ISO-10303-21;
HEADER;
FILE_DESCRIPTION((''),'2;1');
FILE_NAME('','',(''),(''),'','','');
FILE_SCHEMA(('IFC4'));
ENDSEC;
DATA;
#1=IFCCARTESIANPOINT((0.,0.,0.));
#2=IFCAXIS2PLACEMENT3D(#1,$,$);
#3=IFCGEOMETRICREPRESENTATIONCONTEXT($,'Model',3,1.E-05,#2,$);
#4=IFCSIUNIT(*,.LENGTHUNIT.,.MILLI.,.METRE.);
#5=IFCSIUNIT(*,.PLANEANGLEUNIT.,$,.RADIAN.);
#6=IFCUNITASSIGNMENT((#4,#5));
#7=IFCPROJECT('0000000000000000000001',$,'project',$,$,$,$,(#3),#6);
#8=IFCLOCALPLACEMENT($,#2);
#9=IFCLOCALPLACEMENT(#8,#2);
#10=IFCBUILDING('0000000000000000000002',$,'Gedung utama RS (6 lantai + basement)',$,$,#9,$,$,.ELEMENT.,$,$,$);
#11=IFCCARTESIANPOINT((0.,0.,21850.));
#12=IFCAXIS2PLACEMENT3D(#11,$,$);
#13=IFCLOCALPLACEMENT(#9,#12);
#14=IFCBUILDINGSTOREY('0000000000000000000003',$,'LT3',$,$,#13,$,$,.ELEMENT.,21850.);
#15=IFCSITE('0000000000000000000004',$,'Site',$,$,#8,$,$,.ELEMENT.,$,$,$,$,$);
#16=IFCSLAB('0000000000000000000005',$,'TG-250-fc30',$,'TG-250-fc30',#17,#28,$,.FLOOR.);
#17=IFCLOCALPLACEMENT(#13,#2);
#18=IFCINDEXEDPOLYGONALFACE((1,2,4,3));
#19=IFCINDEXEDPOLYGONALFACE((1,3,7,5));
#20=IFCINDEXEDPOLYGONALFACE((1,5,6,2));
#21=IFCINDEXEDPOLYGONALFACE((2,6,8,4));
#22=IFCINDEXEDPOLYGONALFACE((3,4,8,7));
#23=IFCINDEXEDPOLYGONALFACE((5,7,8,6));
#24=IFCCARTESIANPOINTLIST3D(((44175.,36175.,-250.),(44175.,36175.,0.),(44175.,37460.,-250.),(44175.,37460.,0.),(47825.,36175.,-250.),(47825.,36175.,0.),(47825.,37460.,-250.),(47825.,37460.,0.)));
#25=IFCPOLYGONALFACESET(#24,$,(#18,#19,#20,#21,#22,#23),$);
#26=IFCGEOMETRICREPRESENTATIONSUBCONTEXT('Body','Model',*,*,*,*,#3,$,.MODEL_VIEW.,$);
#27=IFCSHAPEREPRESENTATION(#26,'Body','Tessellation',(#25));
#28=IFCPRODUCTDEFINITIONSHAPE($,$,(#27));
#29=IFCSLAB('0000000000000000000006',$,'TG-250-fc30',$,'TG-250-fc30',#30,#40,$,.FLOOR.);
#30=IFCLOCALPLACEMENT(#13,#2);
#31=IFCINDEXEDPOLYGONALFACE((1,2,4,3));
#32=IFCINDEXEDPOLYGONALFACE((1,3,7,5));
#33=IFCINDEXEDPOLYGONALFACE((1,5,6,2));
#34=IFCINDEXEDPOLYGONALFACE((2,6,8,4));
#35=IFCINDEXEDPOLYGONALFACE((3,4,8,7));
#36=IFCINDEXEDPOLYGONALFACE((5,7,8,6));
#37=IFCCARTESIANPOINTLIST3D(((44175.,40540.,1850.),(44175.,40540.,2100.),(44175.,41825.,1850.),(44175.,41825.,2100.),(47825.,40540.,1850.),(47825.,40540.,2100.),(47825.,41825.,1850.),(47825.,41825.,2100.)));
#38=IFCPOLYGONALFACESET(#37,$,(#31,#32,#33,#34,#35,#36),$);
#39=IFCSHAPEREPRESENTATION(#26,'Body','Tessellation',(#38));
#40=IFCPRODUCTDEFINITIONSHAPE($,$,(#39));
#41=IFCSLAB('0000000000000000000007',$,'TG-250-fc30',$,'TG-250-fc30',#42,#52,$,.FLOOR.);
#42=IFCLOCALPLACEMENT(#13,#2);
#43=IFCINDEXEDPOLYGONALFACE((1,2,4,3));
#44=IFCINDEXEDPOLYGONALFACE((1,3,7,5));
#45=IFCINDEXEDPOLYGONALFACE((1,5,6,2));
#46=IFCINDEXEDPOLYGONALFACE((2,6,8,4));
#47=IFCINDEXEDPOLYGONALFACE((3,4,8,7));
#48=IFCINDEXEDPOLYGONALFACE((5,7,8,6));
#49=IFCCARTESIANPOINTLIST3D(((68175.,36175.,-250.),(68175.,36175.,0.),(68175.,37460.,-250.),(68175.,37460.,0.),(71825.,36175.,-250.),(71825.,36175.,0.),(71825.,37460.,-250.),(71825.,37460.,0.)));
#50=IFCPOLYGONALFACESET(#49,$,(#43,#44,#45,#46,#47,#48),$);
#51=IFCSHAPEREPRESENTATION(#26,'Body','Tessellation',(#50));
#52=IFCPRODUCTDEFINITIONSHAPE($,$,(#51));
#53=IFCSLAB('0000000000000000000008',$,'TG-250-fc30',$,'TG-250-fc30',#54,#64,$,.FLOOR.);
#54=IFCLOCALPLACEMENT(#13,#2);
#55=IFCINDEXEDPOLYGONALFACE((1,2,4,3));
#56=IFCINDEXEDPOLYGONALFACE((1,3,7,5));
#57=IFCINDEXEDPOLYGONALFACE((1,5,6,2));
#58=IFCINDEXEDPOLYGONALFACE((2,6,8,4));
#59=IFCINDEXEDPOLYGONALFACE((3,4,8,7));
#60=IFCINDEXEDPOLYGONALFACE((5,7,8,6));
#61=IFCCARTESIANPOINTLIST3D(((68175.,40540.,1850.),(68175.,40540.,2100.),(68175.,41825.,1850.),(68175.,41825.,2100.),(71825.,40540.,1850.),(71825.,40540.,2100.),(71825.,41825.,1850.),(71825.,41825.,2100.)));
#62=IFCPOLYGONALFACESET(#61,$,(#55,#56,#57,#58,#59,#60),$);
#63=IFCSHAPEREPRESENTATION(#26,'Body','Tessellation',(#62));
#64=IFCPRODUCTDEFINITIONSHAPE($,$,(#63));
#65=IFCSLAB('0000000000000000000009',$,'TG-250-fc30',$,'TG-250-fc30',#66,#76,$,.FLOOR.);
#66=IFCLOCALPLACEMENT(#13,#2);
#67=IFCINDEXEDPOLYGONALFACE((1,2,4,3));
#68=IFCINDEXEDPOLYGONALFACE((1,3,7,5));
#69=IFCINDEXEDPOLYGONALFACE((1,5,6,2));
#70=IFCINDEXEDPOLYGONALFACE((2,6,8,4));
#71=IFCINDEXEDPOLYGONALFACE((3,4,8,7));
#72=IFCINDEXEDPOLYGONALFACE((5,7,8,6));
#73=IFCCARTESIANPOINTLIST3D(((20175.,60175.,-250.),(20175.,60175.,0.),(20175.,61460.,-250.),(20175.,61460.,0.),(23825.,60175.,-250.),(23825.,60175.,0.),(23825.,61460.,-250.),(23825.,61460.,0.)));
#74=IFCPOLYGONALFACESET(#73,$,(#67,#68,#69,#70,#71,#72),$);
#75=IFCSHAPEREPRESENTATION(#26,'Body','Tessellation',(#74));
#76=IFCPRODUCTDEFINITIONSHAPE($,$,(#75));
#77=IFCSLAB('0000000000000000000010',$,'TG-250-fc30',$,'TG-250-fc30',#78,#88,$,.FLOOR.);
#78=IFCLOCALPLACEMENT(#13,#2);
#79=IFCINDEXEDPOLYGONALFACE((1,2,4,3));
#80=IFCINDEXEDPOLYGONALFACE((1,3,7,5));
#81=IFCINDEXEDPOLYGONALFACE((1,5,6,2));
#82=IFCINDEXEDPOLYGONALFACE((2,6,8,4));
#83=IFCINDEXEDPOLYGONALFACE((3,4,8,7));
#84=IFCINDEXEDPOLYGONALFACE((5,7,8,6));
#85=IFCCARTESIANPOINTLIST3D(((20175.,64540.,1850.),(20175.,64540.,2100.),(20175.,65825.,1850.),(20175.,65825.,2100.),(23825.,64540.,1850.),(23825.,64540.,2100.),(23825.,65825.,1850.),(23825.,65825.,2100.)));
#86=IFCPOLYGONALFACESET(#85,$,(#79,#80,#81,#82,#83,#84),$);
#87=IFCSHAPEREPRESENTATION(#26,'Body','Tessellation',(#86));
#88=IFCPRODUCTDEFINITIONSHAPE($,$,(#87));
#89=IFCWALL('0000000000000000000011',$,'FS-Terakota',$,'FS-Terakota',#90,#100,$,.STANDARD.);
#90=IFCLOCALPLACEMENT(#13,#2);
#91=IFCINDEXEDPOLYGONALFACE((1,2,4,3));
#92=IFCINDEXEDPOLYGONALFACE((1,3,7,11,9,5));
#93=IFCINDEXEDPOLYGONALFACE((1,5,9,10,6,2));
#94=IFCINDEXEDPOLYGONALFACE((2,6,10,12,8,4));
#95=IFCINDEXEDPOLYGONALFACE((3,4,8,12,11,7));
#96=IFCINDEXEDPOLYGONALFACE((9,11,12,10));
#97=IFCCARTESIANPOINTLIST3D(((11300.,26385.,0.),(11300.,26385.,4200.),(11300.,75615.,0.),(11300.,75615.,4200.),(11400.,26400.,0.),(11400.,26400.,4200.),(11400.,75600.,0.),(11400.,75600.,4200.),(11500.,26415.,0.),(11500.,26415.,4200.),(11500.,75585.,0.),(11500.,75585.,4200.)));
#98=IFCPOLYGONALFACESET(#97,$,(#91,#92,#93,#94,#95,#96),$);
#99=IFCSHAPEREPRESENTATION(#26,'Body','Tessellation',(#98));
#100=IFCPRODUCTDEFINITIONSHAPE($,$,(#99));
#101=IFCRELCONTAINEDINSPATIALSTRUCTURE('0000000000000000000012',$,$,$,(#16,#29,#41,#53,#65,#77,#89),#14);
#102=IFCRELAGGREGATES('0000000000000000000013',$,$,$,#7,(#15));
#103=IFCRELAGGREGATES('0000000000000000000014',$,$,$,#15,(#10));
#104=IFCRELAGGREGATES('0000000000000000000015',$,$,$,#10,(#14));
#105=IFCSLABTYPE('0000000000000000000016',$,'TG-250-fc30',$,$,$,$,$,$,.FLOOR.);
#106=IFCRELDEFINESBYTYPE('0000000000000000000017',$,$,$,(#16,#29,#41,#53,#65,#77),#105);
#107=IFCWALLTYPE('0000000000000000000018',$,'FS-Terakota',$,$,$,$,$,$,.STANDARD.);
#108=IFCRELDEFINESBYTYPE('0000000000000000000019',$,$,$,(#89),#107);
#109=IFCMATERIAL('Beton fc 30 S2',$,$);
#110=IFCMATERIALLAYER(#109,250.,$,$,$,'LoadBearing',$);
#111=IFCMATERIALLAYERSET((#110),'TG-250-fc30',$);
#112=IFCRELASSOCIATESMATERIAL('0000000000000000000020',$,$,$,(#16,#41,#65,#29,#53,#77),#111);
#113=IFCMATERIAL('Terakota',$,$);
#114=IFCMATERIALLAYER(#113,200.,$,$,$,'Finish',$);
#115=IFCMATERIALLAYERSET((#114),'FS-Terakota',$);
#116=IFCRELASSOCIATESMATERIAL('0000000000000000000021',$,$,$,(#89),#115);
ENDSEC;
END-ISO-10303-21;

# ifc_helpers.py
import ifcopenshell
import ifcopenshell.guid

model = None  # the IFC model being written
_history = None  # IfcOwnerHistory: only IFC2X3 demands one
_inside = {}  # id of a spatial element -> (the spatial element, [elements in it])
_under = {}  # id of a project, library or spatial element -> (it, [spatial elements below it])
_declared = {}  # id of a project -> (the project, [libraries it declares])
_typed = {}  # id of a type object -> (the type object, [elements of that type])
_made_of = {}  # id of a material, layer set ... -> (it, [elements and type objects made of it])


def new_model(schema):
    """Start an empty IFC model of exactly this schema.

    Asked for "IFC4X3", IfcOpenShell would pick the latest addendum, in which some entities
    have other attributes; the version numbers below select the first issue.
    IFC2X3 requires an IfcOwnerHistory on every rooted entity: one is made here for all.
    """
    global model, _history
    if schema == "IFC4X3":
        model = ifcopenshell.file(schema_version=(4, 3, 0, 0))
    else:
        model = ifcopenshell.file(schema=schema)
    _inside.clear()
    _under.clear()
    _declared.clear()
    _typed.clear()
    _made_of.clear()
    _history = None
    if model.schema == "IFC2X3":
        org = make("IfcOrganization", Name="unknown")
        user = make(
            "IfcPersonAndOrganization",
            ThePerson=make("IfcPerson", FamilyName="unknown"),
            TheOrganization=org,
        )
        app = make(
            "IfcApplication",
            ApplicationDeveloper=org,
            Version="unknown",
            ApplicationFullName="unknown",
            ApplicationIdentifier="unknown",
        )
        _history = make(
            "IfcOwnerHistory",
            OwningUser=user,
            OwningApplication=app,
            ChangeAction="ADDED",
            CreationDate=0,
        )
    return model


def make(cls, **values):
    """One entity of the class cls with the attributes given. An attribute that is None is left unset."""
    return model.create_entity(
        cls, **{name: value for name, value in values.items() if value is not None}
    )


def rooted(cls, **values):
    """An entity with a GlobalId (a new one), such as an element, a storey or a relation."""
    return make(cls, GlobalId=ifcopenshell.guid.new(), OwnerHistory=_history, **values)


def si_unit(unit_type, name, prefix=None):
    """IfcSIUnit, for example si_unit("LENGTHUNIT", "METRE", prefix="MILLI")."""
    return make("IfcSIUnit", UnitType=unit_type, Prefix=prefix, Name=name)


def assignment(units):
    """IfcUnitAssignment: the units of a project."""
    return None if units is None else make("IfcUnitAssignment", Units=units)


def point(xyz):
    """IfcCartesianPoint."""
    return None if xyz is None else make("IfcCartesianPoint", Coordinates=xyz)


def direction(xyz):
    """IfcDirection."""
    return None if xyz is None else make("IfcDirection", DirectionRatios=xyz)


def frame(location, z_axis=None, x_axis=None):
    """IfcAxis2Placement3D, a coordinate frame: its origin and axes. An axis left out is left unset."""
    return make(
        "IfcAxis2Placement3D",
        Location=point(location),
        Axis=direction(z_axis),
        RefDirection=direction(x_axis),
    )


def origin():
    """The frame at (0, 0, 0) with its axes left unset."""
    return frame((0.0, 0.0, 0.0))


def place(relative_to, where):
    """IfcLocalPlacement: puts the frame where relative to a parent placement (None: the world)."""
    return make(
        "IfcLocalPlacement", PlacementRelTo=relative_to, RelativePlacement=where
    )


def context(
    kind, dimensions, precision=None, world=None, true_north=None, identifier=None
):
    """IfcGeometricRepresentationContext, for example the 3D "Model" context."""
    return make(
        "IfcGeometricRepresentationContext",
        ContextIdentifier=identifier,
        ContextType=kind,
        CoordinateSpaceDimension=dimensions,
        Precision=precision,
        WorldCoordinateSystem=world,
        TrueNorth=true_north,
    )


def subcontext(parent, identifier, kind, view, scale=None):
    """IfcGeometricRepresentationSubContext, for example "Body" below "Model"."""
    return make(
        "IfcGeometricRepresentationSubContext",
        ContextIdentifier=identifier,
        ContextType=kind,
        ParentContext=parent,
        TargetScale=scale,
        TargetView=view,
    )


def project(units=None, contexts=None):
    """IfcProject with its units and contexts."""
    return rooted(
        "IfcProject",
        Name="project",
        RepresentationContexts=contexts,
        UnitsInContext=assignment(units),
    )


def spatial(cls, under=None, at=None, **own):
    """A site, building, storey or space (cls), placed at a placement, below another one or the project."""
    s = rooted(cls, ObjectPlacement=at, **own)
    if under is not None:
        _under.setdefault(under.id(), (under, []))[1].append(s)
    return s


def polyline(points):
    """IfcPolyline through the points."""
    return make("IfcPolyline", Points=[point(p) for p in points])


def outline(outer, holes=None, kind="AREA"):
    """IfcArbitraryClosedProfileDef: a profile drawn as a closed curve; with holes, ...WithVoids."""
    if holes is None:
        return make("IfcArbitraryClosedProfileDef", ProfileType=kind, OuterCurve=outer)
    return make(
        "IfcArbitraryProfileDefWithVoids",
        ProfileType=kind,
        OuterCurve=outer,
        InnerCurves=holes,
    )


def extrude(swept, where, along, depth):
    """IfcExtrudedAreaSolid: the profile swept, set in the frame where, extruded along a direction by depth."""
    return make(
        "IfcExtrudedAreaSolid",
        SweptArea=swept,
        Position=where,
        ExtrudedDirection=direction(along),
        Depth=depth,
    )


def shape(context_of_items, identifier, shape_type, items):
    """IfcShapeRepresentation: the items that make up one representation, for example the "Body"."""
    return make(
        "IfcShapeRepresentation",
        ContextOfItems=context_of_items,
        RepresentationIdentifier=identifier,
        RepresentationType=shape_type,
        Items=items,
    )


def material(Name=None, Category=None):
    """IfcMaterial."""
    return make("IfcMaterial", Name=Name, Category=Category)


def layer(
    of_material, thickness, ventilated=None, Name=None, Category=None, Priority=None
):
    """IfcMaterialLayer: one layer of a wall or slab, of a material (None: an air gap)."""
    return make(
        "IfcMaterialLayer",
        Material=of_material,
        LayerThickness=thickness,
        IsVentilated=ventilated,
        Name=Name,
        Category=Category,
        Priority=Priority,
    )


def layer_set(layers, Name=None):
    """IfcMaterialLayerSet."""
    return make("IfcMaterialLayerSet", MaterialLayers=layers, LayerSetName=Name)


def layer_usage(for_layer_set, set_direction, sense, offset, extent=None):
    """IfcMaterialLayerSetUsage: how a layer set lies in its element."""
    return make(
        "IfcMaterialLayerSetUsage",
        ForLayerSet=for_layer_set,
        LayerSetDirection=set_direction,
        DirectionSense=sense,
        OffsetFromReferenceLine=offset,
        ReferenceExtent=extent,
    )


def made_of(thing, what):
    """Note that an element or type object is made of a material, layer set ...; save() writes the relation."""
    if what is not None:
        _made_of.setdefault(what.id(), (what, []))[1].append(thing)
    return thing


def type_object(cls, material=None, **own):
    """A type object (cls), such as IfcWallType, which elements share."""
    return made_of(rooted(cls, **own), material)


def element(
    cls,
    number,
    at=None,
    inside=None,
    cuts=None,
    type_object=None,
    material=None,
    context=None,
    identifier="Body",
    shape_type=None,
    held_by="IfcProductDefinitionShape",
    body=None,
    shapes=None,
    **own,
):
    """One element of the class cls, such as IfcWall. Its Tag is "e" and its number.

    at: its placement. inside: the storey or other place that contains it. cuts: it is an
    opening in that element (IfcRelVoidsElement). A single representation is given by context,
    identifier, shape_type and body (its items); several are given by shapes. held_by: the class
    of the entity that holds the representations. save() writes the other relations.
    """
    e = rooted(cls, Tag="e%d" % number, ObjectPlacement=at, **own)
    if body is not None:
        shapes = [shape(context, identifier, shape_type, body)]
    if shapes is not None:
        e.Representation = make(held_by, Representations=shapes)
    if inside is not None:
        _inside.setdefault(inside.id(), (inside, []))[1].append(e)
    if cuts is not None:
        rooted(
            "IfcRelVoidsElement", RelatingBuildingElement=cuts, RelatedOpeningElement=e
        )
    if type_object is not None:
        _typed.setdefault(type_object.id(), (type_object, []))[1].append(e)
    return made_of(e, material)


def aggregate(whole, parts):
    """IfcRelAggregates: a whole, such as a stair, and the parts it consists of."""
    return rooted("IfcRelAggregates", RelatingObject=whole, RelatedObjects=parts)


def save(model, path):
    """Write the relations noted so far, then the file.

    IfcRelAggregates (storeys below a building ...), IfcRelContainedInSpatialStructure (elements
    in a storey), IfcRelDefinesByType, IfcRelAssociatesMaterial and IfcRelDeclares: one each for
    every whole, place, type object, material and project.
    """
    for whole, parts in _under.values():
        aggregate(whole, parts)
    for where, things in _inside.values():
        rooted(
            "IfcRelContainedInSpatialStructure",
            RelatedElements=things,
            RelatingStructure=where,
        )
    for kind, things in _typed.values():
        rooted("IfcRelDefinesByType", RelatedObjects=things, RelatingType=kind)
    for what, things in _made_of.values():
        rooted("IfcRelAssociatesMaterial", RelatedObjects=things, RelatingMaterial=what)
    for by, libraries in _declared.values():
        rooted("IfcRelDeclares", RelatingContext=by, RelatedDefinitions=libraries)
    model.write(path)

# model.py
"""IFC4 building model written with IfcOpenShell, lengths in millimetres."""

from ifc_helpers import new_model, si_unit, frame, origin, place, context, subcontext, project, spatial, polyline, outline, extrude, material, layer, layer_set, layer_usage, type_object, element, save


model = new_model("IFC4")

# Units and contexts
model_context = context("Model", 3, precision=1e-05, world=origin())
body_context = subcontext(model_context, "Body", "Model", "MODEL_VIEW")
ifc_project = project(units=[si_unit("LENGTHUNIT", "METRE", prefix="MILLI"), si_unit("PLANEANGLEUNIT", "RADIAN")], contexts=[model_context])

# Site, building, storey
site_placement = place(None, origin())
site = spatial("IfcSite", under=ifc_project, at=site_placement, Name="Site", CompositionType="ELEMENT")
building_placement = place(site_placement, origin())
building = spatial("IfcBuilding", under=site, at=building_placement, Name="Gedung utama RS (6 lantai + basement)", CompositionType="ELEMENT")
storey_placement = place(building_placement, frame((0.0, 0.0, 21850.0)))
storey = spatial("IfcBuildingStorey", under=building, at=storey_placement, Name="LT3", CompositionType="ELEMENT", Elevation=21850.0)

# Shared definitions
ifc_material_1 = material(Name="Beton fc 30 S2")

# Slabs
ifc_layer_1 = layer(ifc_material_1, 250.0, Category="LoadBearing")
ifc_layer_set_1 = layer_set([ifc_layer_1], Name="TG-250-fc30")
ifc_layer_usage_1 = layer_usage(ifc_layer_set_1, "AXIS3", "NEGATIVE", 0.0)
slab_type_1 = type_object("IfcSlabType", Name="TG-250-fc30", PredefinedType="FLOOR")
ifc_layer_usage_2 = layer_usage(ifc_layer_set_1, "AXIS3", "NEGATIVE", 2100.0)
slab_1_placement = place(storey_placement, origin())
element("IfcSlab", 1, at=slab_1_placement, inside=storey, type_object=slab_type_1, material=ifc_layer_usage_1, Name="TG-250-fc30", ObjectType="TG-250-fc30", PredefinedType="FLOOR", context=body_context, shape_type="SweptSolid", body=[
    extrude(outline(polyline([(47825.0, 36175.0), (47825.0, 37460.0), (44175.0, 37460.0), (44175.0, 36175.0), (47825.0, 36175.0)])), frame((0.0, 0.0, -250.0)), (0.0, 0.0, 1.0), 250.0),
])
slab_2_placement = place(storey_placement, origin())
element("IfcSlab", 2, at=slab_2_placement, inside=storey, type_object=slab_type_1, material=ifc_layer_usage_2, Name="TG-250-fc30", ObjectType="TG-250-fc30", PredefinedType="FLOOR", context=body_context, shape_type="SweptSolid", body=[
    extrude(outline(polyline([(47825.0, 40540.0), (47825.0, 41825.0), (44175.0, 41825.0), (44175.0, 40540.0), (47825.0, 40540.0)])), frame((0.0, 0.0, 1850.0)), (0.0, 0.0, 1.0), 250.0),
])
slab_3_placement = place(storey_placement, origin())
element("IfcSlab", 3, at=slab_3_placement, inside=storey, type_object=slab_type_1, material=ifc_layer_usage_1, Name="TG-250-fc30", ObjectType="TG-250-fc30", PredefinedType="FLOOR", context=body_context, shape_type="SweptSolid", body=[
    extrude(outline(polyline([(71825.0, 36175.0), (71825.0, 37460.0), (68175.0, 37460.0), (68175.0, 36175.0), (71825.0, 36175.0)])), frame((0.0, 0.0, -250.0)), (0.0, 0.0, 1.0), 250.0),
])
slab_4_placement = place(storey_placement, origin())
element("IfcSlab", 4, at=slab_4_placement, inside=storey, type_object=slab_type_1, material=ifc_layer_usage_2, Name="TG-250-fc30", ObjectType="TG-250-fc30", PredefinedType="FLOOR", context=body_context, shape_type="SweptSolid", body=[
    extrude(outline(polyline([(71825.0, 40540.0), (71825.0, 41825.0), (68175.0, 41825.0), (68175.0, 40540.0), (71825.0, 40540.0)])), frame((0.0, 0.0, 1850.0)), (0.0, 0.0, 1.0), 250.0),
])
slab_5_placement = place(storey_placement, origin())
element("IfcSlab", 5, at=slab_5_placement, inside=storey, type_object=slab_type_1, material=ifc_layer_usage_1, Name="TG-250-fc30", ObjectType="TG-250-fc30", PredefinedType="FLOOR", context=body_context, shape_type="SweptSolid", body=[
    extrude(outline(polyline([(23825.0, 60175.0), (23825.0, 61460.0), (20175.0, 61460.0), (20175.0, 60175.0), (23825.0, 60175.0)])), frame((0.0, 0.0, -250.0)), (0.0, 0.0, 1.0), 250.0),
])
slab_6_placement = place(storey_placement, origin())
element("IfcSlab", 6, at=slab_6_placement, inside=storey, type_object=slab_type_1, material=ifc_layer_usage_2, Name="TG-250-fc30", ObjectType="TG-250-fc30", PredefinedType="FLOOR", context=body_context, shape_type="SweptSolid", body=[
    extrude(outline(polyline([(23825.0, 64540.0), (23825.0, 65825.0), (20175.0, 65825.0), (20175.0, 64540.0), (23825.0, 64540.0)])), frame((0.0, 0.0, 1850.0)), (0.0, 0.0, 1.0), 250.0),
])

# Wall
ifc_material_2 = material(Name="Terakota")
ifc_layer_2 = layer(ifc_material_2, 200.0, Category="Finish")
ifc_layer_set_2 = layer_set([ifc_layer_2], Name="FS-Terakota")
ifc_layer_usage_3 = layer_usage(ifc_layer_set_2, "AXIS2", "NEGATIVE", 100.0)
wall_type = type_object("IfcWallType", Name="FS-Terakota", PredefinedType="STANDARD")
wall_placement = place(storey_placement, frame((11400.0, 26400.0, 0.0), z_axis=(0.0, 0.0, 1.0), x_axis=(0.0, 1.0, 0.0)))
element("IfcWall", 7, at=wall_placement, inside=storey, type_object=wall_type, material=ifc_layer_usage_3, Name="FS-Terakota", ObjectType="FS-Terakota", PredefinedType="STANDARD", context=body_context, shape_type="SweptSolid", body=[
    extrude(outline(polyline([(15.0, -100.0), (0.0, 0.0), (-15.0, 100.0), (49215.0, 100.0), (49200.0, 0.0), (49185.0, -100.0), (15.0, -100.0)])), origin(), (0.0, 0.0, 1.0), 4200.0),
])

save(model, "model.ifc")
